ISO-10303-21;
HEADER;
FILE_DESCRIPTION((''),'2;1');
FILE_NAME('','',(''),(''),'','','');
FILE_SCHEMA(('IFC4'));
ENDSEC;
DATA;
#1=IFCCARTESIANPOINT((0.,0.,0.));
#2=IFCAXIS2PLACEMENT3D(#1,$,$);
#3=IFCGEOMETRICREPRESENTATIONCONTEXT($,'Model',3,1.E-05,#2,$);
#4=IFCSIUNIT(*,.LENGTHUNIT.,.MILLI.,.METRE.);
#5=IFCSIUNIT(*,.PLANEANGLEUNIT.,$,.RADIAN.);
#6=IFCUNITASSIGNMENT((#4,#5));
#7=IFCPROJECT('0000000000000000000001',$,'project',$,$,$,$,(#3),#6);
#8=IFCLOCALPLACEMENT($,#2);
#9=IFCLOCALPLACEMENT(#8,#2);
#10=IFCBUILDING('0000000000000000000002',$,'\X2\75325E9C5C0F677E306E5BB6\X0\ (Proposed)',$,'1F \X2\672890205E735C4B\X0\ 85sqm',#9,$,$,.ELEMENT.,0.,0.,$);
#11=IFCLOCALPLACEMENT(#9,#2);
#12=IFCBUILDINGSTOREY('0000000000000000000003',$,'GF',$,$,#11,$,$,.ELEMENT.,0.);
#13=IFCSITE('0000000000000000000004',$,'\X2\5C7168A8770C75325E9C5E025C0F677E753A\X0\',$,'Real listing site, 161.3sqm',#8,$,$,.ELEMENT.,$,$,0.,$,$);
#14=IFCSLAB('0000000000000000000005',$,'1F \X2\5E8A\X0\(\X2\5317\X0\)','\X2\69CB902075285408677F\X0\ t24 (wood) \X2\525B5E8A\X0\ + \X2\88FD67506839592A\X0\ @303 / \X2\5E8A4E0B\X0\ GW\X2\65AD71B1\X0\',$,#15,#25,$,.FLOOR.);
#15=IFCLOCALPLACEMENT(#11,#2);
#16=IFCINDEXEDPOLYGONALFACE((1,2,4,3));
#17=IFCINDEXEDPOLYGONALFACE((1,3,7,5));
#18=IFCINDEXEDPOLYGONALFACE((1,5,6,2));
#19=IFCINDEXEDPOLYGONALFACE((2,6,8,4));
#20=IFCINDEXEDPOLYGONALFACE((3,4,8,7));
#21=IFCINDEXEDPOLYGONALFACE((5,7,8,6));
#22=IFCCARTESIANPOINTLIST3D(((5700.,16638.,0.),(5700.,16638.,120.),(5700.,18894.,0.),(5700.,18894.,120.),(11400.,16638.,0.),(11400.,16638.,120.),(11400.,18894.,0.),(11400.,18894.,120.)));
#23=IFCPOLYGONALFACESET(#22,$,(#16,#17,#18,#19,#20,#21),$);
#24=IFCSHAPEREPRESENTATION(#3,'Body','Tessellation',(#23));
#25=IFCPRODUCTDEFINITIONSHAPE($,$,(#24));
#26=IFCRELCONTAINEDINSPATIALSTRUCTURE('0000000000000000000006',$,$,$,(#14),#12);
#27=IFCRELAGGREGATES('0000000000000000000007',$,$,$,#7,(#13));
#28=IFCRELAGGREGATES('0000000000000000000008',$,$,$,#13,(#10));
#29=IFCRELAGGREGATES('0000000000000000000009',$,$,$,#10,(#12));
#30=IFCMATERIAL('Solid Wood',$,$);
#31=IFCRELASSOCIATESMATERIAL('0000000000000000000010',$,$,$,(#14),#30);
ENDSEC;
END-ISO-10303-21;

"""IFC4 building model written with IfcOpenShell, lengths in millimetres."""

from ifc_helpers import new_model, si_unit, frame, frame_2d, origin, place, context, project, spatial, rectangle, extrude, material, element, save


model = new_model("IFC4")

# Units and contexts
model_context = context("Model", 3, precision=1e-05, world=origin())
ifc_project = project(units=[si_unit("LENGTHUNIT", "METRE", prefix="MILLI"), si_unit("PLANEANGLEUNIT", "RADIAN")], contexts=[model_context])

# Site, building, storey
site_placement = place(None, origin())
site = spatial("IfcSite", under=ifc_project, at=site_placement, Name="山梨県甲府市小松町", ObjectType="Real listing site, 161.3sqm", CompositionType="ELEMENT", RefElevation=0.0)
building_placement = place(site_placement, origin())
building = spatial("IfcBuilding", under=site, at=building_placement, Name="甲府小松の家 (Proposed)", ObjectType="1F 木造平屋 85sqm", CompositionType="ELEMENT", ElevationOfRefHeight=0.0, ElevationOfTerrain=0.0)
storey_placement = place(building_placement, origin())
storey = spatial("IfcBuildingStorey", under=building, at=storey_placement, Name="GF", CompositionType="ELEMENT", Elevation=0.0)

# Slab
ifc_material_1 = material(Name="Solid Wood")
slab_1_placement = place(storey_placement, frame((2850.0, 8319.0, 0.0)))
element("IfcSlab", 1, at=slab_1_placement, inside=storey, material=ifc_material_1, Name="1F 床(北)", Description="構造用合板 t24 (wood) 剛床 + 製材根太 @303 / 床下 GW断熱", PredefinedType="FLOOR", context=model_context, shape_type="SweptSolid", body=[
    extrude(rectangle(XDim=5700.0, YDim=2256.0, at=frame_2d((2850.0, 1128.0))), frame((2850.0, 8319.0, 0.0)), (0.0, 0.0, 1.0), 120.0),
])

save(model, "model.ifc")
